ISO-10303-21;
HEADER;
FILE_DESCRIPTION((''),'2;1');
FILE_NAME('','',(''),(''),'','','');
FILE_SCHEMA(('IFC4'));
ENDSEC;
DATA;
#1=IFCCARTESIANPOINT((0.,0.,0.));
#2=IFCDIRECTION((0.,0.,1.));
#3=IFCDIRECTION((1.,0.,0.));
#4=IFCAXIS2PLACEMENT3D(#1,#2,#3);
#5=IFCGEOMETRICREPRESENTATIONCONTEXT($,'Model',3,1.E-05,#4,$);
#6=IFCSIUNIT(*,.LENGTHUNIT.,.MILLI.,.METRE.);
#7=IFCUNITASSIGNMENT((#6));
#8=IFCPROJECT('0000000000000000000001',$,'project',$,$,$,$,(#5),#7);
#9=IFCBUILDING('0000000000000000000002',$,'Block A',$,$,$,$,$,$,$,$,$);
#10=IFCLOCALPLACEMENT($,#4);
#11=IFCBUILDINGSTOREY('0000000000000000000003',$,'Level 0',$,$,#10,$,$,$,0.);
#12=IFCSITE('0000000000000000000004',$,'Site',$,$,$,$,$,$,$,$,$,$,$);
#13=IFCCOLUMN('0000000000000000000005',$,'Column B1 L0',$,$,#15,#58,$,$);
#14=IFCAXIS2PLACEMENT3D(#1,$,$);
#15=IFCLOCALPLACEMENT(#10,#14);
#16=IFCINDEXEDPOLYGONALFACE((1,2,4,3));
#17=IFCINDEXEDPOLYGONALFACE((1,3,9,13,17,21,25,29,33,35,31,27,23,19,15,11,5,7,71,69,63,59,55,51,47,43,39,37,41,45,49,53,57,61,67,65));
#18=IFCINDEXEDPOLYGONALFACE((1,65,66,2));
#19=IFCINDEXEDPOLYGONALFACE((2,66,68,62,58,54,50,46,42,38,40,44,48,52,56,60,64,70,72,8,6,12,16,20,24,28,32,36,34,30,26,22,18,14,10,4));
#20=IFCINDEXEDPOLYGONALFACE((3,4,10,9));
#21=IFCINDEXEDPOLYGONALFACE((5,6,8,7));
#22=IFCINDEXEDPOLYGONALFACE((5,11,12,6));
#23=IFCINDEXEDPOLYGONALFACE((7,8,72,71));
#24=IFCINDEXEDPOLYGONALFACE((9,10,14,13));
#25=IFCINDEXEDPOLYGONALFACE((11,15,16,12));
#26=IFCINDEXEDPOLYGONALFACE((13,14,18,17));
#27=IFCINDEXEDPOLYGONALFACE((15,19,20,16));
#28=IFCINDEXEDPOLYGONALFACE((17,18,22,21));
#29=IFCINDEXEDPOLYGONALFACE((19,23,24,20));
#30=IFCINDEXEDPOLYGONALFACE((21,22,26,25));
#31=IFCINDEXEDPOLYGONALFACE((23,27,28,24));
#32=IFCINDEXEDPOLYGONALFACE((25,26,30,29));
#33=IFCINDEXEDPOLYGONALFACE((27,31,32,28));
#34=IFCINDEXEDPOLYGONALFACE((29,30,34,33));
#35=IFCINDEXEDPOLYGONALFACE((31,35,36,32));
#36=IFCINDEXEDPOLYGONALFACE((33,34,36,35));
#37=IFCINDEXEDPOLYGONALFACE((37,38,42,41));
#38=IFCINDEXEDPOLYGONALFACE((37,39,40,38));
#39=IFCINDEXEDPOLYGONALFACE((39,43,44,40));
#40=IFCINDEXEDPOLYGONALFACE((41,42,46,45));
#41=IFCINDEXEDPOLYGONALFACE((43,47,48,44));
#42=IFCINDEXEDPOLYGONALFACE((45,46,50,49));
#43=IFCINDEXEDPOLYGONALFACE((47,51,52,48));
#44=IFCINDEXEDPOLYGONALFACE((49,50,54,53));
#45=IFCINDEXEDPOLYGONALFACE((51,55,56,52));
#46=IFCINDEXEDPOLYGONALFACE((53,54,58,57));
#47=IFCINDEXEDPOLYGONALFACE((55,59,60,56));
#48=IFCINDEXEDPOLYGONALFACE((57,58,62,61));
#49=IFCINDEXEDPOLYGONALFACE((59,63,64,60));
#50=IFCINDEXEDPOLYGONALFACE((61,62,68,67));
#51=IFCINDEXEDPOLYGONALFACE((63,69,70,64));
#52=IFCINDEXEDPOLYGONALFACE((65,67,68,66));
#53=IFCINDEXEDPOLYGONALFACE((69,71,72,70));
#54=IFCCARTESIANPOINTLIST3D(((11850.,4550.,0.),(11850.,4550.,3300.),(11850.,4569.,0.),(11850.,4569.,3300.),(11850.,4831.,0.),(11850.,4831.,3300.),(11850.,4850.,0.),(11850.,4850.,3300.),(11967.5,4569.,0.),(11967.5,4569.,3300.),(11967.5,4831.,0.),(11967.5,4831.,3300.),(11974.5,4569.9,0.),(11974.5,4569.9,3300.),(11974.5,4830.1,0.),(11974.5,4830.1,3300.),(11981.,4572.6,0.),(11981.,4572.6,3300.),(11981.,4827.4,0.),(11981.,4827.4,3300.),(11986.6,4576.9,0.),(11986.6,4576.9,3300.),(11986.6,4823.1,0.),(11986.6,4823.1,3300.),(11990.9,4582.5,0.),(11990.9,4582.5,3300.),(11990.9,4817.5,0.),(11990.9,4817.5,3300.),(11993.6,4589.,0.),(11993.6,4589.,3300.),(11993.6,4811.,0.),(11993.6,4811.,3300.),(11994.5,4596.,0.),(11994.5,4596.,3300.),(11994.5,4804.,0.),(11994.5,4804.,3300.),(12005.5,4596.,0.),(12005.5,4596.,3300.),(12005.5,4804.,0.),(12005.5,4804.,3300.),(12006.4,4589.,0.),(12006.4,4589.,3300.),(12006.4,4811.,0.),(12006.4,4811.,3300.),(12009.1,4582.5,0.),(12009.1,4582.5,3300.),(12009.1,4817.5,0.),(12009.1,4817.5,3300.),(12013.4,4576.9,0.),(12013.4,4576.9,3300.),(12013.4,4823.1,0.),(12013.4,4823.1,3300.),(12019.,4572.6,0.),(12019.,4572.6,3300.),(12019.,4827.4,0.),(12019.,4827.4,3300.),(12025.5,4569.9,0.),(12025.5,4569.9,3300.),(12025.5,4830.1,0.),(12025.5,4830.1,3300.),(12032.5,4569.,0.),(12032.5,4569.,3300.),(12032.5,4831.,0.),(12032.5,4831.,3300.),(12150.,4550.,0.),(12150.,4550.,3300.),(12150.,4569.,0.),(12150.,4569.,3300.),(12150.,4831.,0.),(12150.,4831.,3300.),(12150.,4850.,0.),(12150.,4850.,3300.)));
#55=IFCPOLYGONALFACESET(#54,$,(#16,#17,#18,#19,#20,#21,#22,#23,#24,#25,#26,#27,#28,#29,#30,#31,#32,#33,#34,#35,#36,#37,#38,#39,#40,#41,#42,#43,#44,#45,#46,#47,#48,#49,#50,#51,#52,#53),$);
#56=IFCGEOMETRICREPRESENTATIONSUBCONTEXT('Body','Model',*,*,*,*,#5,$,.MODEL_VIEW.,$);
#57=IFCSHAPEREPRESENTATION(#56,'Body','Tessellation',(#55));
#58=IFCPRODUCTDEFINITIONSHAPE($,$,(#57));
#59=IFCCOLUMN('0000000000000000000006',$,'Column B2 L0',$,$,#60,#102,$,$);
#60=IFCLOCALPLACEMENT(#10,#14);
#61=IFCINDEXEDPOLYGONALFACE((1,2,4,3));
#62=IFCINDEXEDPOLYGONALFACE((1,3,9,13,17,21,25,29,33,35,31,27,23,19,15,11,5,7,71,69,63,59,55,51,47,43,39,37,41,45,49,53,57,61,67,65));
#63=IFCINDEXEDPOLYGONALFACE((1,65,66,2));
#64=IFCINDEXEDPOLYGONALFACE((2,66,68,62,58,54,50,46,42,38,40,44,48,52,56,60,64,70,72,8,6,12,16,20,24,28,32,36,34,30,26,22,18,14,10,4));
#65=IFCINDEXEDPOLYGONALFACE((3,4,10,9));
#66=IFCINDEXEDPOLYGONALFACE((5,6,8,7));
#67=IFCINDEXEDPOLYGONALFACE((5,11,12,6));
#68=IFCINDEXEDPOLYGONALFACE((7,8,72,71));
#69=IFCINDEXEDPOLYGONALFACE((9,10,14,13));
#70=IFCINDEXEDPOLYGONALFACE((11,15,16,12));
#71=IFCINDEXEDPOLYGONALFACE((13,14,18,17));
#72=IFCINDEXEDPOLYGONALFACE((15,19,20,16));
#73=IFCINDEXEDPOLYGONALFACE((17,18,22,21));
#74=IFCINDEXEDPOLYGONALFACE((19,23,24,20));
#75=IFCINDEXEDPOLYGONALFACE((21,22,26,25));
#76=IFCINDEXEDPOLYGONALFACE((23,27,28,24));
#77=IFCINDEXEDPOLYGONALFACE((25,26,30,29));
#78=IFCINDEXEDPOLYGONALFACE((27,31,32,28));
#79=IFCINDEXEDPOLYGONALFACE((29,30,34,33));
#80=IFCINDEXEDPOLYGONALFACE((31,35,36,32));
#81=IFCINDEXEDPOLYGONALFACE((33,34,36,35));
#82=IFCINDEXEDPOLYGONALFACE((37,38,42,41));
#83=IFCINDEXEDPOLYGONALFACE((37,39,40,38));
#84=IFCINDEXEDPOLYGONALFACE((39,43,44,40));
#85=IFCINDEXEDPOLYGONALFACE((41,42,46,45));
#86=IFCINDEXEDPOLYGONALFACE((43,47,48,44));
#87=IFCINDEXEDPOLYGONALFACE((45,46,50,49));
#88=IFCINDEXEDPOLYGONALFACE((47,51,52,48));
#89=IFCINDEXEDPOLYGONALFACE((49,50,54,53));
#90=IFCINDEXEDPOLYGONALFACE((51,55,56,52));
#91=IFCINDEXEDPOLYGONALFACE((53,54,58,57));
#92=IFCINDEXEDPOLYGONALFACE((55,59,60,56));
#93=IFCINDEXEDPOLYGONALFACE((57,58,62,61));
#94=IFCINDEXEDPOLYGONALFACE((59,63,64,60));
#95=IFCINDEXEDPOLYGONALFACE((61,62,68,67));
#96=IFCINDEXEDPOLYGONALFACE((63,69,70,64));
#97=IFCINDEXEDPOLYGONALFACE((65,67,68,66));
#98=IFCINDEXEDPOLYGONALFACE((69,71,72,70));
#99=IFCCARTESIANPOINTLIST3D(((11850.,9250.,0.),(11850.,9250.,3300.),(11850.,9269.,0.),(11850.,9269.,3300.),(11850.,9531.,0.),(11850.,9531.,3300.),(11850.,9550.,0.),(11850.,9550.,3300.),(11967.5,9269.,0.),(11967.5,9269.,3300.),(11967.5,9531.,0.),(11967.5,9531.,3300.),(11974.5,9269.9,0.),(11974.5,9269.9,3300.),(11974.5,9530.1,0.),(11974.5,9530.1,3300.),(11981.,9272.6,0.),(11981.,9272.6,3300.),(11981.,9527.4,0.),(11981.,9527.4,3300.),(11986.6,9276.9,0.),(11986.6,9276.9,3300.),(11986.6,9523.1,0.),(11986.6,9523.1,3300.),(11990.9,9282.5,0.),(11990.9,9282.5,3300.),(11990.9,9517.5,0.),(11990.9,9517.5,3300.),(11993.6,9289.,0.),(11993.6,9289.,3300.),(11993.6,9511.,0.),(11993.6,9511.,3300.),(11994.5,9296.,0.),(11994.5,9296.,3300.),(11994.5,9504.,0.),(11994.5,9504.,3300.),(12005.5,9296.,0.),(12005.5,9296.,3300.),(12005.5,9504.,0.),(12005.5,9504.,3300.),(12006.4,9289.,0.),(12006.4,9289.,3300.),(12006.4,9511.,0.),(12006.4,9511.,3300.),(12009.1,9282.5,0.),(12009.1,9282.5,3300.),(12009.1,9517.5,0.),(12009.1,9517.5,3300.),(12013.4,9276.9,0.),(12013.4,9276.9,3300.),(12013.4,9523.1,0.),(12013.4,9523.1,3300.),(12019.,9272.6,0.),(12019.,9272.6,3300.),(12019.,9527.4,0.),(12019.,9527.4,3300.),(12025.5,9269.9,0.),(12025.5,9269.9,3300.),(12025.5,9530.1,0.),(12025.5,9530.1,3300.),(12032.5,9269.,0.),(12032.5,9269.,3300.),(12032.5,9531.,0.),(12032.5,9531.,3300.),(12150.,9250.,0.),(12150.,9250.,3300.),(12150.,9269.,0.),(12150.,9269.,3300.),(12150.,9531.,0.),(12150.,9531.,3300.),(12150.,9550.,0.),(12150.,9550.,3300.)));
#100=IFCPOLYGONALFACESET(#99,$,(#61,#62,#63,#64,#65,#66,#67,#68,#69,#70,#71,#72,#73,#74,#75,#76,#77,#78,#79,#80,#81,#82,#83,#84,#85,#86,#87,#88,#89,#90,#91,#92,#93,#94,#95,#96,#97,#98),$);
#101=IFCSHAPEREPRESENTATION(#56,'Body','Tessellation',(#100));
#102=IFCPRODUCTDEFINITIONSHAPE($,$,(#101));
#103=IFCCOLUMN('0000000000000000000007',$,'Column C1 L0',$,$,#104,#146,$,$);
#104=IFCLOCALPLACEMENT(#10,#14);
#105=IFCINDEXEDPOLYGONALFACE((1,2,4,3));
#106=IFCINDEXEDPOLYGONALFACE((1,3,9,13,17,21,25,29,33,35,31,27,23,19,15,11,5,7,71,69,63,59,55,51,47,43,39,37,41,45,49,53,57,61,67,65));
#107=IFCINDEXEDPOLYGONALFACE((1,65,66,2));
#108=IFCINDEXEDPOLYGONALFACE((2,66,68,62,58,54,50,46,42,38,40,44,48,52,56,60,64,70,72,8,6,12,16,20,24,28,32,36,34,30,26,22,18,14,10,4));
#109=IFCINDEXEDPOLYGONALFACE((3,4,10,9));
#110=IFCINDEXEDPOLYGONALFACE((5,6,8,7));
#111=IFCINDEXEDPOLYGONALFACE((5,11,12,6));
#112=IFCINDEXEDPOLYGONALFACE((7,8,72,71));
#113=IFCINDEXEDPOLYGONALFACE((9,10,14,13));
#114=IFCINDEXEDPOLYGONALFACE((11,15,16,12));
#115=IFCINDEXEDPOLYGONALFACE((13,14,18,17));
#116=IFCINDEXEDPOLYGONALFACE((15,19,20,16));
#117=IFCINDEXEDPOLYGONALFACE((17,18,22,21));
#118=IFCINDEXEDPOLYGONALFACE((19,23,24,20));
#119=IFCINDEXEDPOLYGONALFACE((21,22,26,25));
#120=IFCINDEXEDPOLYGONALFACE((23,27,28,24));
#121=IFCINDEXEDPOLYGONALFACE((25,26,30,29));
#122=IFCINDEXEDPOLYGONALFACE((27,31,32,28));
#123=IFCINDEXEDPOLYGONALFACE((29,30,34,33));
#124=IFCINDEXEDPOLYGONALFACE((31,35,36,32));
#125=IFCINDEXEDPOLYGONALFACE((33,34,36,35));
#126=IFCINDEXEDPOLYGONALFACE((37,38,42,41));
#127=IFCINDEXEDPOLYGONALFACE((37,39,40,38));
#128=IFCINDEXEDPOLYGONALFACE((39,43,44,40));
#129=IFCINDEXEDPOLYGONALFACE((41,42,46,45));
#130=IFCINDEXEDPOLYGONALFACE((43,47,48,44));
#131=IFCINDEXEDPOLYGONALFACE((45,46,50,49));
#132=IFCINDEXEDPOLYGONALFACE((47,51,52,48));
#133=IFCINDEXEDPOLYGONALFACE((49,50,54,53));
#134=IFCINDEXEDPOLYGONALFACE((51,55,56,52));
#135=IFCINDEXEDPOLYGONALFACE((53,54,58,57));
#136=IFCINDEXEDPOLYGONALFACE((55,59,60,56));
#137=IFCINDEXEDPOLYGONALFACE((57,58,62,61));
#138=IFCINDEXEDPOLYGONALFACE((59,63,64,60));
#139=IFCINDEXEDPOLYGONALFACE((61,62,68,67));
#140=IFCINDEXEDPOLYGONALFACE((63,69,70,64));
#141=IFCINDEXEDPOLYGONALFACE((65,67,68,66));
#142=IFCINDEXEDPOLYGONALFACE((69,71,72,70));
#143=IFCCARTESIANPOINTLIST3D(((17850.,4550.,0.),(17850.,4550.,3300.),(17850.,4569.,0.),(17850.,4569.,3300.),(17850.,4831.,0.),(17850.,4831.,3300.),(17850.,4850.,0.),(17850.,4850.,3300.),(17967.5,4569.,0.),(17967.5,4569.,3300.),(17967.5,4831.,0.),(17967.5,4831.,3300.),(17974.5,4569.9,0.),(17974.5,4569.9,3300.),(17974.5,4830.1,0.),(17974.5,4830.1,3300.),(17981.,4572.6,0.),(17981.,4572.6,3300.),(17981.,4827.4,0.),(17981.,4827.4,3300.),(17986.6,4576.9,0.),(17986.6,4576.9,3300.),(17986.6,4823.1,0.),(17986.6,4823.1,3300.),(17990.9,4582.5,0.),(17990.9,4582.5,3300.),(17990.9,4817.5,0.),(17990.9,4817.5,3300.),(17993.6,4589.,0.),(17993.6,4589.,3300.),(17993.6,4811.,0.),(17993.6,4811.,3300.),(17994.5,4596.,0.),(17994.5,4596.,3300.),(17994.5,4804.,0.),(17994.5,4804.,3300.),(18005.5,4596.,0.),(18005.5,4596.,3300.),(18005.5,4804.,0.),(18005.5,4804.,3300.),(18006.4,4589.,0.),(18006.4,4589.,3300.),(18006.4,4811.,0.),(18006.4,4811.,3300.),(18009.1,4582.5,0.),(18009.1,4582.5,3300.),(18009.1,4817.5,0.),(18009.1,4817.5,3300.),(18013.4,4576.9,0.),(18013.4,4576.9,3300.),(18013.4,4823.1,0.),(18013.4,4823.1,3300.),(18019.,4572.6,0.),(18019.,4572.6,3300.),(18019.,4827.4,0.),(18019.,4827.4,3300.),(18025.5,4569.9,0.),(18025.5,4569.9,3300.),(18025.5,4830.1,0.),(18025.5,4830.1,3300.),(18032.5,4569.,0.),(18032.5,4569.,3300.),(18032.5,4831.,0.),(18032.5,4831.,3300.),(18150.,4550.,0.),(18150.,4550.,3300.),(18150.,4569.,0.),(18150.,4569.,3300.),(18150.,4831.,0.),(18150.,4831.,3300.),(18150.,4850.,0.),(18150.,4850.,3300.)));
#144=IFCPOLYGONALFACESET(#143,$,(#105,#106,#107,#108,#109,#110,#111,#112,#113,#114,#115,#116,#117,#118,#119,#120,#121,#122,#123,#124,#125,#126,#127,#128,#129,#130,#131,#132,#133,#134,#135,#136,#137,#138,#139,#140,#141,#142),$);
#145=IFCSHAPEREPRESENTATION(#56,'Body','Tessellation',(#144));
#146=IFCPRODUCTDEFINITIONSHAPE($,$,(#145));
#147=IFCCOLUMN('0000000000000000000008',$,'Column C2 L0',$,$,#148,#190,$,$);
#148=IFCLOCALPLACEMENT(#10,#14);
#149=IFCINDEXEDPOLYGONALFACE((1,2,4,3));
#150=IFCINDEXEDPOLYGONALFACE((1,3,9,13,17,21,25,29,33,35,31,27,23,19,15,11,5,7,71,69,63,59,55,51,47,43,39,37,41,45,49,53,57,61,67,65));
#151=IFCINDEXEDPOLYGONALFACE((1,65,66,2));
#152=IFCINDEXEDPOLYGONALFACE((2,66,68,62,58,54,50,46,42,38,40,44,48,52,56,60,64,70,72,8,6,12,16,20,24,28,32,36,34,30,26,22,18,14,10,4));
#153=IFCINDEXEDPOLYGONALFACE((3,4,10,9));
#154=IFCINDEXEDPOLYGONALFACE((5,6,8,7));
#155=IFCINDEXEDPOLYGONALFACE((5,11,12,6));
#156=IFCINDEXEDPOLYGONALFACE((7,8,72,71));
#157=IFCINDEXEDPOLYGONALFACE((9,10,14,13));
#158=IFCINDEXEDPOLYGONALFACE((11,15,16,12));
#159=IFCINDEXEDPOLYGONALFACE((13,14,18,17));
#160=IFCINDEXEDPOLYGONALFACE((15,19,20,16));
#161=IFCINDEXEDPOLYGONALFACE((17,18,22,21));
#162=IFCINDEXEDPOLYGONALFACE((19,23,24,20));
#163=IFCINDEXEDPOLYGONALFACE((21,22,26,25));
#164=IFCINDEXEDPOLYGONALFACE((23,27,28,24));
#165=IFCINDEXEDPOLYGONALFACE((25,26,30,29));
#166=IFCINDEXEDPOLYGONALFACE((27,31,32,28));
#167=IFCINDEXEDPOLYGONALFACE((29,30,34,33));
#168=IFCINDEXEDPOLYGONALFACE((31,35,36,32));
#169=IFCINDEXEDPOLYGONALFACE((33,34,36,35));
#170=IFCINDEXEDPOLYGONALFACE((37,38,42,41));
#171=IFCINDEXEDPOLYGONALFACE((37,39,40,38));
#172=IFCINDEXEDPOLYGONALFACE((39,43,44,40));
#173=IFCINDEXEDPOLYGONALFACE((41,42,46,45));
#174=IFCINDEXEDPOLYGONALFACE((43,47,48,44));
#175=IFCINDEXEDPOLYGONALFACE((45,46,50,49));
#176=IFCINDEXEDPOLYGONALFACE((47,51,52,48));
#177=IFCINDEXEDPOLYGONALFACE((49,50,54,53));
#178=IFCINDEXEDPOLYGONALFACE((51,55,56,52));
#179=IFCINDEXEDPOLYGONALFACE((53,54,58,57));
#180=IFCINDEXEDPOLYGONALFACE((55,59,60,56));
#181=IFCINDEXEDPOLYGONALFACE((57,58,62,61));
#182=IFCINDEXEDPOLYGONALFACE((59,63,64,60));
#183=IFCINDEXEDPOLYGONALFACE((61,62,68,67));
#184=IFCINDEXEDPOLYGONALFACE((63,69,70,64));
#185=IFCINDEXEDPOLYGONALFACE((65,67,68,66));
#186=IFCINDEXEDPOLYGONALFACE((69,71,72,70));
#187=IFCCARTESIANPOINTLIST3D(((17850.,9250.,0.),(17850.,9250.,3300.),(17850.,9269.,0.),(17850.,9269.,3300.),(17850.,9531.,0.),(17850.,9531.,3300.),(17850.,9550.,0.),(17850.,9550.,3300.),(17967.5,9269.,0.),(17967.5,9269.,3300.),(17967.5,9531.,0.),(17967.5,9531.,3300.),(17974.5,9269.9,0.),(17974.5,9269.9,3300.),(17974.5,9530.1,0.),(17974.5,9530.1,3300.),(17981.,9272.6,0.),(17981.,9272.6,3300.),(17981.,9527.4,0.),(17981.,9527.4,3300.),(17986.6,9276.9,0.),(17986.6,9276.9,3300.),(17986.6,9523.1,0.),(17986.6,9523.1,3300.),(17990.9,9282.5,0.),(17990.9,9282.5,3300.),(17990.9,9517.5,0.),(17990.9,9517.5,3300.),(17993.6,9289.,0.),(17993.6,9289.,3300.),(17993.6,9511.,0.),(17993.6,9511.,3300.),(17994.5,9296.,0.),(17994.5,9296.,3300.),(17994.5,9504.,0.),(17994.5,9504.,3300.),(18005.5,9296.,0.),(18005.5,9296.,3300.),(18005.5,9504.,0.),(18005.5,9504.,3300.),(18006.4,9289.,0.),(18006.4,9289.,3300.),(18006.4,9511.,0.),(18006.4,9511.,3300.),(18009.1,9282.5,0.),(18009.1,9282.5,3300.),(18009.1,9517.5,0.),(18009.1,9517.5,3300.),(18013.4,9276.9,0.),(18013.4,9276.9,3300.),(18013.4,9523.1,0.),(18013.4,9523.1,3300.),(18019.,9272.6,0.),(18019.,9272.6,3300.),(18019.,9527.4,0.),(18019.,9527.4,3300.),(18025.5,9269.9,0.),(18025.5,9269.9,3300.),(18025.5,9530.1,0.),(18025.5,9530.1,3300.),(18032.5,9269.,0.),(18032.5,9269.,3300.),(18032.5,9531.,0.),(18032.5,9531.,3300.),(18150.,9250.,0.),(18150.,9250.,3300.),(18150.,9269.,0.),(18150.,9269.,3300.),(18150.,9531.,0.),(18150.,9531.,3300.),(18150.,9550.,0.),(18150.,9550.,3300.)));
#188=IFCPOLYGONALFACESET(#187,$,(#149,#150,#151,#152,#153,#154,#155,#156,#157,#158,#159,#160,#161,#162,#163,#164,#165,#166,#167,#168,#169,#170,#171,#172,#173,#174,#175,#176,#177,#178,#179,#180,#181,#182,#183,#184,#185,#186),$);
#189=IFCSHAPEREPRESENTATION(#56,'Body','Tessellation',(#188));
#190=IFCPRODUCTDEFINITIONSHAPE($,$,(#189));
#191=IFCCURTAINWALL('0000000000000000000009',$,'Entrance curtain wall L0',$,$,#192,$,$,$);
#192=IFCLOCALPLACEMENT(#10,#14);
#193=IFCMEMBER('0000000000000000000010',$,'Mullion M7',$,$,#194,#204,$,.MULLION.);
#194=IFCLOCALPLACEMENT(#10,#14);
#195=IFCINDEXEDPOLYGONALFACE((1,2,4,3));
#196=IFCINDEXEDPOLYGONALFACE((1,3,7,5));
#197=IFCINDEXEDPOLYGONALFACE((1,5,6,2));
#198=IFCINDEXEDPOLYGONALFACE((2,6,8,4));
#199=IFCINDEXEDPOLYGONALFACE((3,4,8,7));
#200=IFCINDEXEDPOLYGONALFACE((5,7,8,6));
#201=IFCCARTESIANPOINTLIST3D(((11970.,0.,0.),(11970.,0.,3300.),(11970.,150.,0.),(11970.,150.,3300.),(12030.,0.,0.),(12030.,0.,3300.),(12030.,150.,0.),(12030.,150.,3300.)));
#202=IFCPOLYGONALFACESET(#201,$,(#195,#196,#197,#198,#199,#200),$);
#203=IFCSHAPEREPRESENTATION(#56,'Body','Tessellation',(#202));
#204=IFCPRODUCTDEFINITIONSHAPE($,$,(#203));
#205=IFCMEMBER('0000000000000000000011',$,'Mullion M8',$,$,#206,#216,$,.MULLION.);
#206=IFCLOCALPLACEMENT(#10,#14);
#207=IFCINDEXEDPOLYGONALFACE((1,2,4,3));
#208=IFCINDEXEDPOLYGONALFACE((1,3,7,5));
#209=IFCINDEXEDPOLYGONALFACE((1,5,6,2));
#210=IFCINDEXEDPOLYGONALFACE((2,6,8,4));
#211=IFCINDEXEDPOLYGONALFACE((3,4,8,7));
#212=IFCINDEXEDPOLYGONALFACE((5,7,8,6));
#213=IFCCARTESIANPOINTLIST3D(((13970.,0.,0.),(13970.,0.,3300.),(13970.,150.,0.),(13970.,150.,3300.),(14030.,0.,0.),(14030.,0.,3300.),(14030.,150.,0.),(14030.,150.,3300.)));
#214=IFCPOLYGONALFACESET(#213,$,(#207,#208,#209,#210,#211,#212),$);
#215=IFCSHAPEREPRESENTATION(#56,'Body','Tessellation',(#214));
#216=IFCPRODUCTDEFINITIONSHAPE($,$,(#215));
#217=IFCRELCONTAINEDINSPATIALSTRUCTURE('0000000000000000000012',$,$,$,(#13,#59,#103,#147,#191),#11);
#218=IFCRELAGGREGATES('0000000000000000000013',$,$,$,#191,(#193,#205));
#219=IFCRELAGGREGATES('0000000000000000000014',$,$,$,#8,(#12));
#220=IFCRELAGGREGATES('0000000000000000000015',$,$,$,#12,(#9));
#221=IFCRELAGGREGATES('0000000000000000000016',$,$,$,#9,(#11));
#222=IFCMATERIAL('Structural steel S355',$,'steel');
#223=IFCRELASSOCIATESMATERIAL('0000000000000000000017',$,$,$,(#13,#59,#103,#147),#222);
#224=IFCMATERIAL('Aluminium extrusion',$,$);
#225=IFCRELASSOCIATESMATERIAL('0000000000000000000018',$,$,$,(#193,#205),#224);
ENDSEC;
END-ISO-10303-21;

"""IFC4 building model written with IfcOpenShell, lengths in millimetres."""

from ifc_helpers import new_model, si_unit, frame, origin_with_axes, place, context, subcontext, project, spatial, rectangle, i_section, extrude, material, material_profile, profile_set, element, aggregate, save


model = new_model("IFC4")

# Units and contexts
model_context = context("Model", 3, precision=1e-05, world=origin_with_axes())
body_context = subcontext(model_context, "Body", "Model", "MODEL_VIEW")
ifc_project = project(units=[si_unit("LENGTHUNIT", "METRE", prefix="MILLI")], contexts=[model_context])

# Site, building, storey
site = spatial("IfcSite", under=ifc_project, Name="Site")
building = spatial("IfcBuilding", under=site, Name="Block A")
storey_placement = place(None, origin_with_axes())
storey = spatial("IfcBuildingStorey", under=building, at=storey_placement, Name="Level 0", Elevation=0.0)

# Columns
ifc_material_1 = material(Name="Structural steel S355", Category="steel")
ifc_material_profile = material_profile(ifc_material_1, i_section(OverallWidth=300.0, OverallDepth=300.0, WebThickness=11.0, FlangeThickness=19.0, FilletRadius=27.0))
ifc_profile_set = profile_set([ifc_material_profile], Name="HEB 300")
for number, where, z_axis, x_axis, name in (
    (1, (12000.0, 4700.0, 0.0), (0.0, 0.0, 1.0), (1.0, 0.0, 0.0), "Column B1 L0"),
    (2, (12000.0, 9400.0, 0.0), (0.0, 0.0, 1.0), (1.0, 0.0, 0.0), "Column B2 L0"),
    (3, (18000.0, 4700.0, 0.0), (0.0, 0.0, 1.0), (1.0, 0.0, 0.0), "Column C1 L0"),
    (4, (18000.0, 9400.0, 0.0), (0.0, 0.0, 1.0), (1.0, 0.0, 0.0), "Column C2 L0"),
):
    element("IfcColumn", number, at=place(storey_placement, frame(where, z_axis=z_axis, x_axis=x_axis)), inside=storey, material=ifc_profile_set, Name=name, context=body_context, shape_type="SweptSolid", body=[
        extrude(i_section(OverallWidth=300.0, OverallDepth=300.0, WebThickness=11.0, FlangeThickness=19.0, FilletRadius=27.0), origin_with_axes(), (0.0, 0.0, 1.0), 3300.0),
    ])

# Curtain wall, members
curtain_wall_placement = place(storey_placement, origin_with_axes())
curtain_wall = element("IfcCurtainWall", 5, at=curtain_wall_placement, inside=storey, Name="Entrance curtain wall L0")
ifc_material_2 = material(Name="Aluminium extrusion")
member_1_placement = place(curtain_wall_placement, frame((12000.0, 75.0, 0.0), z_axis=(0.0, 0.0, 1.0), x_axis=(1.0, 0.0, 0.0)))
member_1 = element("IfcMember", 6, at=member_1_placement, material=ifc_material_2, Name="Mullion M7", PredefinedType="MULLION", context=body_context, shape_type="SweptSolid", body=[
    extrude(rectangle(XDim=60.0, YDim=150.0), origin_with_axes(), (0.0, 0.0, 1.0), 3300.0),
])
member_2_placement = place(curtain_wall_placement, frame((14000.0, 75.0, 0.0), z_axis=(0.0, 0.0, 1.0), x_axis=(1.0, 0.0, 0.0)))
member_2 = element("IfcMember", 7, at=member_2_placement, material=ifc_material_2, Name="Mullion M8", PredefinedType="MULLION", context=body_context, shape_type="SweptSolid", body=[
    extrude(rectangle(XDim=60.0, YDim=150.0), origin_with_axes(), (0.0, 0.0, 1.0), 3300.0),
])
aggregate(curtain_wall, [member_1, member_2])

save(model, "model.ifc")
